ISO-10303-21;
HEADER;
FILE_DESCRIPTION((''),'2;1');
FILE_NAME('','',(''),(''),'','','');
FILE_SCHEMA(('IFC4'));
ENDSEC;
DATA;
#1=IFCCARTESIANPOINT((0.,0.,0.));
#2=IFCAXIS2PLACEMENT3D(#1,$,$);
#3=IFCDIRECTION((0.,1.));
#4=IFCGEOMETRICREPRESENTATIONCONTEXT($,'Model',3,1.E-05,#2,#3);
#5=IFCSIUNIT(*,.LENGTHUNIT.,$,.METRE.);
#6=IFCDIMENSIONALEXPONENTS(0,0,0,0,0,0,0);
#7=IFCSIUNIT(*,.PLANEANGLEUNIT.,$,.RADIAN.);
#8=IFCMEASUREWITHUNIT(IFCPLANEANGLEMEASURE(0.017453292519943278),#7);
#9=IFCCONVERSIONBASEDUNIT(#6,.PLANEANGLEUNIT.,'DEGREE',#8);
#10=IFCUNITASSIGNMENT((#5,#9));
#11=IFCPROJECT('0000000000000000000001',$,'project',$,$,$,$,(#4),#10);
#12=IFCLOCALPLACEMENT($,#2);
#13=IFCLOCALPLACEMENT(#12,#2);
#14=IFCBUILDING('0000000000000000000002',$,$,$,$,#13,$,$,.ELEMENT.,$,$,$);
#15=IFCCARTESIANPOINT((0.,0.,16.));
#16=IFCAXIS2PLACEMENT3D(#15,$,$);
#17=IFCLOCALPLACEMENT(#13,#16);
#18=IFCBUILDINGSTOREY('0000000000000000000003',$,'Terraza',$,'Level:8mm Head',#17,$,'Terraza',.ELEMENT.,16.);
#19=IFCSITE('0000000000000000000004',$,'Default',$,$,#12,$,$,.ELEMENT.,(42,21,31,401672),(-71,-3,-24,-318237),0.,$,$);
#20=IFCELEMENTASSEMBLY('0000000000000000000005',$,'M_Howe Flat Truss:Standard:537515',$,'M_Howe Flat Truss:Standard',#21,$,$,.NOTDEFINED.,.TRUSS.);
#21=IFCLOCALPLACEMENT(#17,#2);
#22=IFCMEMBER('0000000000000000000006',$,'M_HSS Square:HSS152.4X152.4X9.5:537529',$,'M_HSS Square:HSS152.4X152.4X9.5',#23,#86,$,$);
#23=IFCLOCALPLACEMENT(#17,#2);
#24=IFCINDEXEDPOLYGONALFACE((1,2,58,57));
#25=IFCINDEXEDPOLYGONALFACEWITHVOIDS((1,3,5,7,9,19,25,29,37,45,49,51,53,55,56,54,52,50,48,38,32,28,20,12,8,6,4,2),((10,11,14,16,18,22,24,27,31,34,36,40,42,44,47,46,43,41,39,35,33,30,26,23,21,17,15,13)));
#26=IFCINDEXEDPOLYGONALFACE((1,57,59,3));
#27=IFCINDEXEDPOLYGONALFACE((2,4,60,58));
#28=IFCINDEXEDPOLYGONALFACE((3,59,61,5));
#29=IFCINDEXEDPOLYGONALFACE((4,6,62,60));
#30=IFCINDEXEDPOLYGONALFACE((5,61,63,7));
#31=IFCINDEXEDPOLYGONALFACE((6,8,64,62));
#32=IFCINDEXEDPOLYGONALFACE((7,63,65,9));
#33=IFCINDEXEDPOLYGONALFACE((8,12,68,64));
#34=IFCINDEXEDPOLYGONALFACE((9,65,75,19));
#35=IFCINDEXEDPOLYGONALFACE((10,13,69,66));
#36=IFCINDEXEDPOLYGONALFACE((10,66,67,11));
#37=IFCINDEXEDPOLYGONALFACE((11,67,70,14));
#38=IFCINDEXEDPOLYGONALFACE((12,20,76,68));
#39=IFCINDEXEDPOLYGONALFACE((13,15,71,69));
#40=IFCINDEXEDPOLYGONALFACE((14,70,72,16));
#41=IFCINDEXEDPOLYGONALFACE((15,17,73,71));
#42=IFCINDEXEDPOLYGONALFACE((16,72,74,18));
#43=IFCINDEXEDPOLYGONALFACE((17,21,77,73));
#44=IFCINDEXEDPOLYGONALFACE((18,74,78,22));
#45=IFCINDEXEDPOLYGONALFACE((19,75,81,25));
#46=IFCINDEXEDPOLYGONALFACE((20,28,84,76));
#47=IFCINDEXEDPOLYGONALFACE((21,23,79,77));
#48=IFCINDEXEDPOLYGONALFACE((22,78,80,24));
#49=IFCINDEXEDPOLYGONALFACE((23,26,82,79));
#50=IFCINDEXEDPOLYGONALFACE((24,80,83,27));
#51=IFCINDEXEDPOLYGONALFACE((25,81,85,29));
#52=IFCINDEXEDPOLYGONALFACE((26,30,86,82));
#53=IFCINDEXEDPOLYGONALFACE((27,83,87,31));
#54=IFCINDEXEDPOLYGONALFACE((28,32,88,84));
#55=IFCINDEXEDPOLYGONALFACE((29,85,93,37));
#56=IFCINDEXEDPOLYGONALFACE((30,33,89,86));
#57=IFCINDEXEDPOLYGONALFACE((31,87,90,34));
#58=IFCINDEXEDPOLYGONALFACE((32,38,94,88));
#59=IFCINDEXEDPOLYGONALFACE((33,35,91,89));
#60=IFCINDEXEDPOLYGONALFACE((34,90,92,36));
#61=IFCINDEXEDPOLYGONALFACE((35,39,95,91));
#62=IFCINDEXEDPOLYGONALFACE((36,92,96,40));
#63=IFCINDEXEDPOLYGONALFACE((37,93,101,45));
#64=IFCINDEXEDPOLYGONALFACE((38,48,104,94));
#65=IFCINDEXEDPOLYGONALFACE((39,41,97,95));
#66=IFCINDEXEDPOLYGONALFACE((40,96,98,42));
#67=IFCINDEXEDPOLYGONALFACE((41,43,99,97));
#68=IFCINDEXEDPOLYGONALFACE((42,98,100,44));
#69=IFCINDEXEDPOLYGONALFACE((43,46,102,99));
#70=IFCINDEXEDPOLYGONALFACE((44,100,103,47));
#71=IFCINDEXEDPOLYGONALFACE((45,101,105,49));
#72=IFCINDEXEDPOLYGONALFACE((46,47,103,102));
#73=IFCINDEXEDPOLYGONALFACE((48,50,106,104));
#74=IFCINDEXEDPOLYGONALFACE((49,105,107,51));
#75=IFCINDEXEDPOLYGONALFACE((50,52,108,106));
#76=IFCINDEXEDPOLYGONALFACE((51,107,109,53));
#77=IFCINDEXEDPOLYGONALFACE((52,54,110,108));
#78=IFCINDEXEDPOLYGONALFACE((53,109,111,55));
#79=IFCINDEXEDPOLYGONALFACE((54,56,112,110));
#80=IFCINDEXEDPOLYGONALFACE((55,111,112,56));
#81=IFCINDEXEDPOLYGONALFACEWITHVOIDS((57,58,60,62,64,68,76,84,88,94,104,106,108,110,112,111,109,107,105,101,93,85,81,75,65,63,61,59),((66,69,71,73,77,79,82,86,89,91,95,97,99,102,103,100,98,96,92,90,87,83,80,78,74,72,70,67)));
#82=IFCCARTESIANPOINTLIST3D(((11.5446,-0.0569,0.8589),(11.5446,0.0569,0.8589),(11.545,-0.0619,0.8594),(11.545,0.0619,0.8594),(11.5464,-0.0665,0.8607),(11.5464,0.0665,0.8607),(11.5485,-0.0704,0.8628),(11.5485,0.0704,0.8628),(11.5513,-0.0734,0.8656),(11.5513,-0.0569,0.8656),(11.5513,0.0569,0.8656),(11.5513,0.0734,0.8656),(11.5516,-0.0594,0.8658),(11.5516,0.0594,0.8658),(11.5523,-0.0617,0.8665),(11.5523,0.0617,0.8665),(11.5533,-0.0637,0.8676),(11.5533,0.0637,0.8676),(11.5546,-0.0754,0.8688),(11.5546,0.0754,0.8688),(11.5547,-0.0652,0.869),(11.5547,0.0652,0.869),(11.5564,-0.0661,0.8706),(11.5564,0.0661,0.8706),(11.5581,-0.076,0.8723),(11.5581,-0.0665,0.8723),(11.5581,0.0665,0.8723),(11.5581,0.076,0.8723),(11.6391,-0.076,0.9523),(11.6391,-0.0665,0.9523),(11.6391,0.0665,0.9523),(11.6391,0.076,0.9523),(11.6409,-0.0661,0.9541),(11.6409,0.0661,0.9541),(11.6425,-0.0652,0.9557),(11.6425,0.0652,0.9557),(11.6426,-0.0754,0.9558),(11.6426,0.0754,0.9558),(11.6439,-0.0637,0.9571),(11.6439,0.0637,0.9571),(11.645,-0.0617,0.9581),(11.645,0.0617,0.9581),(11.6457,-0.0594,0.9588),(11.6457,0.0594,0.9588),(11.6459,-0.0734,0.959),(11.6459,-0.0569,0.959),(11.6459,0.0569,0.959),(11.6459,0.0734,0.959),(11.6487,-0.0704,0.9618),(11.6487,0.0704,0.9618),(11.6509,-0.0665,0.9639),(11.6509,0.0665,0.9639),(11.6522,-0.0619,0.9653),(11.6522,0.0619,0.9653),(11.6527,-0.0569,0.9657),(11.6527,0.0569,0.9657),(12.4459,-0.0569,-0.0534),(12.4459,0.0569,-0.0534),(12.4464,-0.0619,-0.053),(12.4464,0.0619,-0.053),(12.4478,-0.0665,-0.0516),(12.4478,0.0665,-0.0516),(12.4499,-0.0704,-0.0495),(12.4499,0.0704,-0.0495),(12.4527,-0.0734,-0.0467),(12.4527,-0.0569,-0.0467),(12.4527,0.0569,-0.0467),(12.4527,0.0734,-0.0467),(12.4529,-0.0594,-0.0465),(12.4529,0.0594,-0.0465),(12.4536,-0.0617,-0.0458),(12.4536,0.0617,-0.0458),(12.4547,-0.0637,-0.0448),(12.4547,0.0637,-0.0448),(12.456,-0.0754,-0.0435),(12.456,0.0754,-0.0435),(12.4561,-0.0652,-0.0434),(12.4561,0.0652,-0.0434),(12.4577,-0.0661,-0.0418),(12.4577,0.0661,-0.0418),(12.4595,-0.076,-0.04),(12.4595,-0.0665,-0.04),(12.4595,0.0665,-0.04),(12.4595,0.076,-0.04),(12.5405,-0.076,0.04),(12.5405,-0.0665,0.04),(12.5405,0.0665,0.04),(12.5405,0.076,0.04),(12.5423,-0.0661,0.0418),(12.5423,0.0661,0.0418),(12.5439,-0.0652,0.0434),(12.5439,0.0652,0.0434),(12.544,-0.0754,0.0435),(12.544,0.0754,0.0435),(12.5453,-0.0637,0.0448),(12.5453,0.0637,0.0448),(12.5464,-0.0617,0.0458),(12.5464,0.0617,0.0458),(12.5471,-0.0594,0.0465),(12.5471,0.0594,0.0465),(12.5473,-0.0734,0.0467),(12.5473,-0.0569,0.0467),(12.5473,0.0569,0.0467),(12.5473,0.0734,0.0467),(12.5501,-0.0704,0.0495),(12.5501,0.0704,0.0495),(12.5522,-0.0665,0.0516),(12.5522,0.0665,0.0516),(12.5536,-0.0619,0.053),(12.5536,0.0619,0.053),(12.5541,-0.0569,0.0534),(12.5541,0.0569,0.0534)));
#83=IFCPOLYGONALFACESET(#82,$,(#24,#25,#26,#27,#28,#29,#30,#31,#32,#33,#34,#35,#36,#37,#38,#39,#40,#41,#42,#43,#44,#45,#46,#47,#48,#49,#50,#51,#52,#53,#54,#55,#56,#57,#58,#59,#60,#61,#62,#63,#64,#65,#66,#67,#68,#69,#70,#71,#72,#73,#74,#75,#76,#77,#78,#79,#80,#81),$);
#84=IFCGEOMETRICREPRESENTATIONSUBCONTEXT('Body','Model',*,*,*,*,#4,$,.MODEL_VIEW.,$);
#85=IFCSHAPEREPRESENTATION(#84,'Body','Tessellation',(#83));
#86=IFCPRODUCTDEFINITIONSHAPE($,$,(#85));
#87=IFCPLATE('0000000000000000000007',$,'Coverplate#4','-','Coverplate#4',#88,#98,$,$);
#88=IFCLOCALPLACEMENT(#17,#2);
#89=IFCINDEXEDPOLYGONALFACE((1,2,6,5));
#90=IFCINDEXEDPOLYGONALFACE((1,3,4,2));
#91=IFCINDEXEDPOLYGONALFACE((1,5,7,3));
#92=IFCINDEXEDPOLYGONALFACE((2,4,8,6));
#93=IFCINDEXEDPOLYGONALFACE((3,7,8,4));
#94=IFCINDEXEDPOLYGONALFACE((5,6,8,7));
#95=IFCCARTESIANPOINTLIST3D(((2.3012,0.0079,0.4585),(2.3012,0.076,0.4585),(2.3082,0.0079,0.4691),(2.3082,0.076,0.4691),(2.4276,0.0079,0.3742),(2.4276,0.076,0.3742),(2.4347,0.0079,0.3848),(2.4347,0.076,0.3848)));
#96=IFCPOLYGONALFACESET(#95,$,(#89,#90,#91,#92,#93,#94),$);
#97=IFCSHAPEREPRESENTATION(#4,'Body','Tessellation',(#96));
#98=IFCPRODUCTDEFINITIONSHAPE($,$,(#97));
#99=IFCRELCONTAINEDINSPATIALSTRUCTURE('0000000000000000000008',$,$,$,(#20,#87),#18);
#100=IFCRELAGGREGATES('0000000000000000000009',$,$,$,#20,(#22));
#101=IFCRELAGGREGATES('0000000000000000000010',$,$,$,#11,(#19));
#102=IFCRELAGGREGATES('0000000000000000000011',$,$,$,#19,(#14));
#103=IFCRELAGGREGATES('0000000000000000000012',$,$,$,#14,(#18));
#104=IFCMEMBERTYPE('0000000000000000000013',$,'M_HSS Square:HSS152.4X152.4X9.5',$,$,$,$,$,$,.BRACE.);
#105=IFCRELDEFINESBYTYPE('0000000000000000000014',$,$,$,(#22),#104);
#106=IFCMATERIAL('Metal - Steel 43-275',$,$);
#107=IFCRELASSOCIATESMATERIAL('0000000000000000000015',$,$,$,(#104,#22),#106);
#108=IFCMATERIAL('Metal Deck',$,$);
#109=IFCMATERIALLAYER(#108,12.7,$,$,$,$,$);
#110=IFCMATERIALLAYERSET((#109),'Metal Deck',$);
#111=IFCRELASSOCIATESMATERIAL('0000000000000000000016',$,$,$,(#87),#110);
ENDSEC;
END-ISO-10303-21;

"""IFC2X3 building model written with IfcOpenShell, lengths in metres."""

from ifc_helpers import new_model, entity, si_unit, converted_unit, direction, frame, frame_2d, origin, origin_with_axes, place, context, subcontext, project, spatial, polyline, circle_curve, parameter, trimmed, segment, composite_curve, outline, extrude, source, transform, mapped, material, layer, layer_set, type_object, type_shapes, element, aggregate, save


model = new_model("IFC2X3")

# Units and contexts
model_context = context("Model", 3, precision=1e-05, world=origin(), true_north=direction((0.0, 1.0)))
body_context = subcontext(model_context, "Body", "Model", "MODEL_VIEW")
ifc_project = project(units=[si_unit("LENGTHUNIT", "METRE"), converted_unit("PLANEANGLEUNIT", "DEGREE", entity("IfcPlaneAngleMeasure", 0.017453292519943278), si_unit("PLANEANGLEUNIT", "RADIAN"), dimensions=[0, 0, 0, 0, 0, 0, 0])], contexts=[model_context])

# Site, building, storey
site_placement = place(None, origin())
site = spatial("IfcSite", under=ifc_project, at=site_placement, Name="Default", CompositionType="ELEMENT", RefLatitude=(42, 21, 31, 401672), RefLongitude=(-71, -3, -24, -318237), RefElevation=0.0)
building_placement = place(site_placement, origin())
building = spatial("IfcBuilding", under=site, at=building_placement, CompositionType="ELEMENT")
storey_placement = place(building_placement, frame((0.0, 0.0, 16.0)))
storey = spatial("IfcBuildingStorey", under=building, at=storey_placement, Name="Terraza", ObjectType="Level:8mm Head", LongName="Terraza", CompositionType="ELEMENT", Elevation=16.0)

# Element assembly
assembly_1_placement = place(storey_placement, origin())
assembly_1 = element("IfcElementAssembly", 1, at=assembly_1_placement, inside=storey, Name="M_Howe Flat Truss:Standard:537515", ObjectType="M_Howe Flat Truss:Standard", AssemblyPlace="NOTDEFINED", PredefinedType="TRUSS")
ifc_material_1 = material(Name="Metal - Steel 43-275")

# Member
member_type_1 = type_object("IfcMemberType", Name="M_HSS Square:HSS152.4X152.4X9.5", PredefinedType="BRACE", material=ifc_material_1)
shared_shape_1 = source(origin(), body_context, "Body", "SweptSolid", [
    extrude(outline(composite_curve([segment(polyline([(-0.0569, -0.076), (0.0569, -0.076)]), True, "CONTINUOUS"), segment(trimmed(circle_curve(frame_2d((0.0569, -0.0569), x_axis=(0.0, 1.0)), 0.0191), [parameter(180.0)], [parameter(270.0)], True, "PARAMETER"), True, "CONTINUOUS"), segment(polyline([(0.076, -0.0569), (0.076, 0.0569)]), True, "CONTINUOUS"), segment(trimmed(circle_curve(frame_2d((0.0569, 0.0569), x_axis=(0.0, 1.0)), 0.0191), [parameter(270.0)], [parameter(0.0)], True, "PARAMETER"), True, "CONTINUOUS"), segment(polyline([(0.0569, 0.076), (-0.0569, 0.076)]), True, "CONTINUOUS"), segment(trimmed(circle_curve(frame_2d((-0.0569, 0.0569), x_axis=(0.0, 1.0)), 0.0191), [parameter(0.0)], [parameter(90.0)], True, "PARAMETER"), True, "CONTINUOUS"), segment(polyline([(-0.076, 0.0569), (-0.076, -0.0569)]), True, "CONTINUOUS"), segment(trimmed(circle_curve(frame_2d((-0.0569, -0.0569), x_axis=(0.0, 1.0)), 0.0191), [parameter(90.0)], [parameter(180.0)], True, "PARAMETER"), True, "CONTINUOUS")], self_intersect=False), holes=[composite_curve([segment(trimmed(circle_curve(frame_2d((-0.0569, 0.0569), x_axis=(0.0, 1.0)), 0.0095), [parameter(360.0)], [parameter(90.0)], True, "PARAMETER"), False, "CONTINUOUS"), segment(polyline([(-0.0569, 0.0665), (0.0569, 0.0665)]), True, "CONTINUOUS"), segment(trimmed(circle_curve(frame_2d((0.0569, 0.0569), x_axis=(0.0, 1.0)), 0.0095), [parameter(270.0)], [parameter(360.0)], True, "PARAMETER"), False, "CONTINUOUS"), segment(polyline([(0.0665, 0.0569), (0.0665, -0.0569)]), True, "CONTINUOUS"), segment(trimmed(circle_curve(frame_2d((0.0569, -0.0569), x_axis=(0.0, 1.0)), 0.0095), [parameter(180.0)], [parameter(270.0)], True, "PARAMETER"), False, "CONTINUOUS"), segment(polyline([(0.0569, -0.0665), (-0.0569, -0.0665)]), True, "CONTINUOUS"), segment(trimmed(circle_curve(frame_2d((-0.0569, -0.0569), x_axis=(0.0, 1.0)), 0.0095), [parameter(90.0)], [parameter(180.0)], True, "PARAMETER"), False, "CONTINUOUS"), segment(polyline([(-0.0665, -0.0569), (-0.0665, 0.0569)]), True, "CONTINUOUS")], self_intersect=False)]), frame((-0.5357, 0.0, 0.0), z_axis=(1.0, 0.0, 0.0), x_axis=(0.0, 0.0, -1.0)), (0.0, 0.0, 1.0), 1.2825),
])
type_shapes(member_type_1, [shared_shape_1])
member_1_placement = place(assembly_1_placement, frame((11.9751, 0.0, 0.5312), z_axis=(-0.711368, 0.0, -0.702819), x_axis=(0.702819, 0.0, -0.711368)))
member_1 = element("IfcMember", 2, at=member_1_placement, type_object=member_type_1, material=ifc_material_1, Name="M_HSS Square:HSS152.4X152.4X9.5:537529", ObjectType="M_HSS Square:HSS152.4X152.4X9.5", context=body_context, shape_type="MappedRepresentation", body=[
    mapped(shared_shape_1, transform((0.0, 0.0, 0.0), scale=1.0)),
])
aggregate(assembly_1, [member_1])

# Plate
ifc_material_2 = material(Name="Metal Deck")
ifc_layer = layer(ifc_material_2, 12.7)
ifc_layer_set = layer_set([ifc_layer], Name="Metal Deck")
plate_placement = place(storey_placement, frame((2.4347, 0.0079, 0.3848), z_axis=(-0.5547, 0.0, -0.83205), x_axis=(-0.83205, 0.0, 0.5547)))
element("IfcPlate", 3, at=plate_placement, inside=storey, material=ifc_layer_set, Name="Coverplate#4", Description="-", ObjectType="Coverplate#4", context=model_context, shape_type="SweptSolid", body=[
    extrude(outline(polyline([(0.0, 0.0), (0.152, 0.0), (0.152, 0.0681), (0.0, 0.0681), (0.0, 0.0)])), origin_with_axes(), (0.0, 0.0, 1.0), 0.0127),
])

save(model, "model.ifc")
